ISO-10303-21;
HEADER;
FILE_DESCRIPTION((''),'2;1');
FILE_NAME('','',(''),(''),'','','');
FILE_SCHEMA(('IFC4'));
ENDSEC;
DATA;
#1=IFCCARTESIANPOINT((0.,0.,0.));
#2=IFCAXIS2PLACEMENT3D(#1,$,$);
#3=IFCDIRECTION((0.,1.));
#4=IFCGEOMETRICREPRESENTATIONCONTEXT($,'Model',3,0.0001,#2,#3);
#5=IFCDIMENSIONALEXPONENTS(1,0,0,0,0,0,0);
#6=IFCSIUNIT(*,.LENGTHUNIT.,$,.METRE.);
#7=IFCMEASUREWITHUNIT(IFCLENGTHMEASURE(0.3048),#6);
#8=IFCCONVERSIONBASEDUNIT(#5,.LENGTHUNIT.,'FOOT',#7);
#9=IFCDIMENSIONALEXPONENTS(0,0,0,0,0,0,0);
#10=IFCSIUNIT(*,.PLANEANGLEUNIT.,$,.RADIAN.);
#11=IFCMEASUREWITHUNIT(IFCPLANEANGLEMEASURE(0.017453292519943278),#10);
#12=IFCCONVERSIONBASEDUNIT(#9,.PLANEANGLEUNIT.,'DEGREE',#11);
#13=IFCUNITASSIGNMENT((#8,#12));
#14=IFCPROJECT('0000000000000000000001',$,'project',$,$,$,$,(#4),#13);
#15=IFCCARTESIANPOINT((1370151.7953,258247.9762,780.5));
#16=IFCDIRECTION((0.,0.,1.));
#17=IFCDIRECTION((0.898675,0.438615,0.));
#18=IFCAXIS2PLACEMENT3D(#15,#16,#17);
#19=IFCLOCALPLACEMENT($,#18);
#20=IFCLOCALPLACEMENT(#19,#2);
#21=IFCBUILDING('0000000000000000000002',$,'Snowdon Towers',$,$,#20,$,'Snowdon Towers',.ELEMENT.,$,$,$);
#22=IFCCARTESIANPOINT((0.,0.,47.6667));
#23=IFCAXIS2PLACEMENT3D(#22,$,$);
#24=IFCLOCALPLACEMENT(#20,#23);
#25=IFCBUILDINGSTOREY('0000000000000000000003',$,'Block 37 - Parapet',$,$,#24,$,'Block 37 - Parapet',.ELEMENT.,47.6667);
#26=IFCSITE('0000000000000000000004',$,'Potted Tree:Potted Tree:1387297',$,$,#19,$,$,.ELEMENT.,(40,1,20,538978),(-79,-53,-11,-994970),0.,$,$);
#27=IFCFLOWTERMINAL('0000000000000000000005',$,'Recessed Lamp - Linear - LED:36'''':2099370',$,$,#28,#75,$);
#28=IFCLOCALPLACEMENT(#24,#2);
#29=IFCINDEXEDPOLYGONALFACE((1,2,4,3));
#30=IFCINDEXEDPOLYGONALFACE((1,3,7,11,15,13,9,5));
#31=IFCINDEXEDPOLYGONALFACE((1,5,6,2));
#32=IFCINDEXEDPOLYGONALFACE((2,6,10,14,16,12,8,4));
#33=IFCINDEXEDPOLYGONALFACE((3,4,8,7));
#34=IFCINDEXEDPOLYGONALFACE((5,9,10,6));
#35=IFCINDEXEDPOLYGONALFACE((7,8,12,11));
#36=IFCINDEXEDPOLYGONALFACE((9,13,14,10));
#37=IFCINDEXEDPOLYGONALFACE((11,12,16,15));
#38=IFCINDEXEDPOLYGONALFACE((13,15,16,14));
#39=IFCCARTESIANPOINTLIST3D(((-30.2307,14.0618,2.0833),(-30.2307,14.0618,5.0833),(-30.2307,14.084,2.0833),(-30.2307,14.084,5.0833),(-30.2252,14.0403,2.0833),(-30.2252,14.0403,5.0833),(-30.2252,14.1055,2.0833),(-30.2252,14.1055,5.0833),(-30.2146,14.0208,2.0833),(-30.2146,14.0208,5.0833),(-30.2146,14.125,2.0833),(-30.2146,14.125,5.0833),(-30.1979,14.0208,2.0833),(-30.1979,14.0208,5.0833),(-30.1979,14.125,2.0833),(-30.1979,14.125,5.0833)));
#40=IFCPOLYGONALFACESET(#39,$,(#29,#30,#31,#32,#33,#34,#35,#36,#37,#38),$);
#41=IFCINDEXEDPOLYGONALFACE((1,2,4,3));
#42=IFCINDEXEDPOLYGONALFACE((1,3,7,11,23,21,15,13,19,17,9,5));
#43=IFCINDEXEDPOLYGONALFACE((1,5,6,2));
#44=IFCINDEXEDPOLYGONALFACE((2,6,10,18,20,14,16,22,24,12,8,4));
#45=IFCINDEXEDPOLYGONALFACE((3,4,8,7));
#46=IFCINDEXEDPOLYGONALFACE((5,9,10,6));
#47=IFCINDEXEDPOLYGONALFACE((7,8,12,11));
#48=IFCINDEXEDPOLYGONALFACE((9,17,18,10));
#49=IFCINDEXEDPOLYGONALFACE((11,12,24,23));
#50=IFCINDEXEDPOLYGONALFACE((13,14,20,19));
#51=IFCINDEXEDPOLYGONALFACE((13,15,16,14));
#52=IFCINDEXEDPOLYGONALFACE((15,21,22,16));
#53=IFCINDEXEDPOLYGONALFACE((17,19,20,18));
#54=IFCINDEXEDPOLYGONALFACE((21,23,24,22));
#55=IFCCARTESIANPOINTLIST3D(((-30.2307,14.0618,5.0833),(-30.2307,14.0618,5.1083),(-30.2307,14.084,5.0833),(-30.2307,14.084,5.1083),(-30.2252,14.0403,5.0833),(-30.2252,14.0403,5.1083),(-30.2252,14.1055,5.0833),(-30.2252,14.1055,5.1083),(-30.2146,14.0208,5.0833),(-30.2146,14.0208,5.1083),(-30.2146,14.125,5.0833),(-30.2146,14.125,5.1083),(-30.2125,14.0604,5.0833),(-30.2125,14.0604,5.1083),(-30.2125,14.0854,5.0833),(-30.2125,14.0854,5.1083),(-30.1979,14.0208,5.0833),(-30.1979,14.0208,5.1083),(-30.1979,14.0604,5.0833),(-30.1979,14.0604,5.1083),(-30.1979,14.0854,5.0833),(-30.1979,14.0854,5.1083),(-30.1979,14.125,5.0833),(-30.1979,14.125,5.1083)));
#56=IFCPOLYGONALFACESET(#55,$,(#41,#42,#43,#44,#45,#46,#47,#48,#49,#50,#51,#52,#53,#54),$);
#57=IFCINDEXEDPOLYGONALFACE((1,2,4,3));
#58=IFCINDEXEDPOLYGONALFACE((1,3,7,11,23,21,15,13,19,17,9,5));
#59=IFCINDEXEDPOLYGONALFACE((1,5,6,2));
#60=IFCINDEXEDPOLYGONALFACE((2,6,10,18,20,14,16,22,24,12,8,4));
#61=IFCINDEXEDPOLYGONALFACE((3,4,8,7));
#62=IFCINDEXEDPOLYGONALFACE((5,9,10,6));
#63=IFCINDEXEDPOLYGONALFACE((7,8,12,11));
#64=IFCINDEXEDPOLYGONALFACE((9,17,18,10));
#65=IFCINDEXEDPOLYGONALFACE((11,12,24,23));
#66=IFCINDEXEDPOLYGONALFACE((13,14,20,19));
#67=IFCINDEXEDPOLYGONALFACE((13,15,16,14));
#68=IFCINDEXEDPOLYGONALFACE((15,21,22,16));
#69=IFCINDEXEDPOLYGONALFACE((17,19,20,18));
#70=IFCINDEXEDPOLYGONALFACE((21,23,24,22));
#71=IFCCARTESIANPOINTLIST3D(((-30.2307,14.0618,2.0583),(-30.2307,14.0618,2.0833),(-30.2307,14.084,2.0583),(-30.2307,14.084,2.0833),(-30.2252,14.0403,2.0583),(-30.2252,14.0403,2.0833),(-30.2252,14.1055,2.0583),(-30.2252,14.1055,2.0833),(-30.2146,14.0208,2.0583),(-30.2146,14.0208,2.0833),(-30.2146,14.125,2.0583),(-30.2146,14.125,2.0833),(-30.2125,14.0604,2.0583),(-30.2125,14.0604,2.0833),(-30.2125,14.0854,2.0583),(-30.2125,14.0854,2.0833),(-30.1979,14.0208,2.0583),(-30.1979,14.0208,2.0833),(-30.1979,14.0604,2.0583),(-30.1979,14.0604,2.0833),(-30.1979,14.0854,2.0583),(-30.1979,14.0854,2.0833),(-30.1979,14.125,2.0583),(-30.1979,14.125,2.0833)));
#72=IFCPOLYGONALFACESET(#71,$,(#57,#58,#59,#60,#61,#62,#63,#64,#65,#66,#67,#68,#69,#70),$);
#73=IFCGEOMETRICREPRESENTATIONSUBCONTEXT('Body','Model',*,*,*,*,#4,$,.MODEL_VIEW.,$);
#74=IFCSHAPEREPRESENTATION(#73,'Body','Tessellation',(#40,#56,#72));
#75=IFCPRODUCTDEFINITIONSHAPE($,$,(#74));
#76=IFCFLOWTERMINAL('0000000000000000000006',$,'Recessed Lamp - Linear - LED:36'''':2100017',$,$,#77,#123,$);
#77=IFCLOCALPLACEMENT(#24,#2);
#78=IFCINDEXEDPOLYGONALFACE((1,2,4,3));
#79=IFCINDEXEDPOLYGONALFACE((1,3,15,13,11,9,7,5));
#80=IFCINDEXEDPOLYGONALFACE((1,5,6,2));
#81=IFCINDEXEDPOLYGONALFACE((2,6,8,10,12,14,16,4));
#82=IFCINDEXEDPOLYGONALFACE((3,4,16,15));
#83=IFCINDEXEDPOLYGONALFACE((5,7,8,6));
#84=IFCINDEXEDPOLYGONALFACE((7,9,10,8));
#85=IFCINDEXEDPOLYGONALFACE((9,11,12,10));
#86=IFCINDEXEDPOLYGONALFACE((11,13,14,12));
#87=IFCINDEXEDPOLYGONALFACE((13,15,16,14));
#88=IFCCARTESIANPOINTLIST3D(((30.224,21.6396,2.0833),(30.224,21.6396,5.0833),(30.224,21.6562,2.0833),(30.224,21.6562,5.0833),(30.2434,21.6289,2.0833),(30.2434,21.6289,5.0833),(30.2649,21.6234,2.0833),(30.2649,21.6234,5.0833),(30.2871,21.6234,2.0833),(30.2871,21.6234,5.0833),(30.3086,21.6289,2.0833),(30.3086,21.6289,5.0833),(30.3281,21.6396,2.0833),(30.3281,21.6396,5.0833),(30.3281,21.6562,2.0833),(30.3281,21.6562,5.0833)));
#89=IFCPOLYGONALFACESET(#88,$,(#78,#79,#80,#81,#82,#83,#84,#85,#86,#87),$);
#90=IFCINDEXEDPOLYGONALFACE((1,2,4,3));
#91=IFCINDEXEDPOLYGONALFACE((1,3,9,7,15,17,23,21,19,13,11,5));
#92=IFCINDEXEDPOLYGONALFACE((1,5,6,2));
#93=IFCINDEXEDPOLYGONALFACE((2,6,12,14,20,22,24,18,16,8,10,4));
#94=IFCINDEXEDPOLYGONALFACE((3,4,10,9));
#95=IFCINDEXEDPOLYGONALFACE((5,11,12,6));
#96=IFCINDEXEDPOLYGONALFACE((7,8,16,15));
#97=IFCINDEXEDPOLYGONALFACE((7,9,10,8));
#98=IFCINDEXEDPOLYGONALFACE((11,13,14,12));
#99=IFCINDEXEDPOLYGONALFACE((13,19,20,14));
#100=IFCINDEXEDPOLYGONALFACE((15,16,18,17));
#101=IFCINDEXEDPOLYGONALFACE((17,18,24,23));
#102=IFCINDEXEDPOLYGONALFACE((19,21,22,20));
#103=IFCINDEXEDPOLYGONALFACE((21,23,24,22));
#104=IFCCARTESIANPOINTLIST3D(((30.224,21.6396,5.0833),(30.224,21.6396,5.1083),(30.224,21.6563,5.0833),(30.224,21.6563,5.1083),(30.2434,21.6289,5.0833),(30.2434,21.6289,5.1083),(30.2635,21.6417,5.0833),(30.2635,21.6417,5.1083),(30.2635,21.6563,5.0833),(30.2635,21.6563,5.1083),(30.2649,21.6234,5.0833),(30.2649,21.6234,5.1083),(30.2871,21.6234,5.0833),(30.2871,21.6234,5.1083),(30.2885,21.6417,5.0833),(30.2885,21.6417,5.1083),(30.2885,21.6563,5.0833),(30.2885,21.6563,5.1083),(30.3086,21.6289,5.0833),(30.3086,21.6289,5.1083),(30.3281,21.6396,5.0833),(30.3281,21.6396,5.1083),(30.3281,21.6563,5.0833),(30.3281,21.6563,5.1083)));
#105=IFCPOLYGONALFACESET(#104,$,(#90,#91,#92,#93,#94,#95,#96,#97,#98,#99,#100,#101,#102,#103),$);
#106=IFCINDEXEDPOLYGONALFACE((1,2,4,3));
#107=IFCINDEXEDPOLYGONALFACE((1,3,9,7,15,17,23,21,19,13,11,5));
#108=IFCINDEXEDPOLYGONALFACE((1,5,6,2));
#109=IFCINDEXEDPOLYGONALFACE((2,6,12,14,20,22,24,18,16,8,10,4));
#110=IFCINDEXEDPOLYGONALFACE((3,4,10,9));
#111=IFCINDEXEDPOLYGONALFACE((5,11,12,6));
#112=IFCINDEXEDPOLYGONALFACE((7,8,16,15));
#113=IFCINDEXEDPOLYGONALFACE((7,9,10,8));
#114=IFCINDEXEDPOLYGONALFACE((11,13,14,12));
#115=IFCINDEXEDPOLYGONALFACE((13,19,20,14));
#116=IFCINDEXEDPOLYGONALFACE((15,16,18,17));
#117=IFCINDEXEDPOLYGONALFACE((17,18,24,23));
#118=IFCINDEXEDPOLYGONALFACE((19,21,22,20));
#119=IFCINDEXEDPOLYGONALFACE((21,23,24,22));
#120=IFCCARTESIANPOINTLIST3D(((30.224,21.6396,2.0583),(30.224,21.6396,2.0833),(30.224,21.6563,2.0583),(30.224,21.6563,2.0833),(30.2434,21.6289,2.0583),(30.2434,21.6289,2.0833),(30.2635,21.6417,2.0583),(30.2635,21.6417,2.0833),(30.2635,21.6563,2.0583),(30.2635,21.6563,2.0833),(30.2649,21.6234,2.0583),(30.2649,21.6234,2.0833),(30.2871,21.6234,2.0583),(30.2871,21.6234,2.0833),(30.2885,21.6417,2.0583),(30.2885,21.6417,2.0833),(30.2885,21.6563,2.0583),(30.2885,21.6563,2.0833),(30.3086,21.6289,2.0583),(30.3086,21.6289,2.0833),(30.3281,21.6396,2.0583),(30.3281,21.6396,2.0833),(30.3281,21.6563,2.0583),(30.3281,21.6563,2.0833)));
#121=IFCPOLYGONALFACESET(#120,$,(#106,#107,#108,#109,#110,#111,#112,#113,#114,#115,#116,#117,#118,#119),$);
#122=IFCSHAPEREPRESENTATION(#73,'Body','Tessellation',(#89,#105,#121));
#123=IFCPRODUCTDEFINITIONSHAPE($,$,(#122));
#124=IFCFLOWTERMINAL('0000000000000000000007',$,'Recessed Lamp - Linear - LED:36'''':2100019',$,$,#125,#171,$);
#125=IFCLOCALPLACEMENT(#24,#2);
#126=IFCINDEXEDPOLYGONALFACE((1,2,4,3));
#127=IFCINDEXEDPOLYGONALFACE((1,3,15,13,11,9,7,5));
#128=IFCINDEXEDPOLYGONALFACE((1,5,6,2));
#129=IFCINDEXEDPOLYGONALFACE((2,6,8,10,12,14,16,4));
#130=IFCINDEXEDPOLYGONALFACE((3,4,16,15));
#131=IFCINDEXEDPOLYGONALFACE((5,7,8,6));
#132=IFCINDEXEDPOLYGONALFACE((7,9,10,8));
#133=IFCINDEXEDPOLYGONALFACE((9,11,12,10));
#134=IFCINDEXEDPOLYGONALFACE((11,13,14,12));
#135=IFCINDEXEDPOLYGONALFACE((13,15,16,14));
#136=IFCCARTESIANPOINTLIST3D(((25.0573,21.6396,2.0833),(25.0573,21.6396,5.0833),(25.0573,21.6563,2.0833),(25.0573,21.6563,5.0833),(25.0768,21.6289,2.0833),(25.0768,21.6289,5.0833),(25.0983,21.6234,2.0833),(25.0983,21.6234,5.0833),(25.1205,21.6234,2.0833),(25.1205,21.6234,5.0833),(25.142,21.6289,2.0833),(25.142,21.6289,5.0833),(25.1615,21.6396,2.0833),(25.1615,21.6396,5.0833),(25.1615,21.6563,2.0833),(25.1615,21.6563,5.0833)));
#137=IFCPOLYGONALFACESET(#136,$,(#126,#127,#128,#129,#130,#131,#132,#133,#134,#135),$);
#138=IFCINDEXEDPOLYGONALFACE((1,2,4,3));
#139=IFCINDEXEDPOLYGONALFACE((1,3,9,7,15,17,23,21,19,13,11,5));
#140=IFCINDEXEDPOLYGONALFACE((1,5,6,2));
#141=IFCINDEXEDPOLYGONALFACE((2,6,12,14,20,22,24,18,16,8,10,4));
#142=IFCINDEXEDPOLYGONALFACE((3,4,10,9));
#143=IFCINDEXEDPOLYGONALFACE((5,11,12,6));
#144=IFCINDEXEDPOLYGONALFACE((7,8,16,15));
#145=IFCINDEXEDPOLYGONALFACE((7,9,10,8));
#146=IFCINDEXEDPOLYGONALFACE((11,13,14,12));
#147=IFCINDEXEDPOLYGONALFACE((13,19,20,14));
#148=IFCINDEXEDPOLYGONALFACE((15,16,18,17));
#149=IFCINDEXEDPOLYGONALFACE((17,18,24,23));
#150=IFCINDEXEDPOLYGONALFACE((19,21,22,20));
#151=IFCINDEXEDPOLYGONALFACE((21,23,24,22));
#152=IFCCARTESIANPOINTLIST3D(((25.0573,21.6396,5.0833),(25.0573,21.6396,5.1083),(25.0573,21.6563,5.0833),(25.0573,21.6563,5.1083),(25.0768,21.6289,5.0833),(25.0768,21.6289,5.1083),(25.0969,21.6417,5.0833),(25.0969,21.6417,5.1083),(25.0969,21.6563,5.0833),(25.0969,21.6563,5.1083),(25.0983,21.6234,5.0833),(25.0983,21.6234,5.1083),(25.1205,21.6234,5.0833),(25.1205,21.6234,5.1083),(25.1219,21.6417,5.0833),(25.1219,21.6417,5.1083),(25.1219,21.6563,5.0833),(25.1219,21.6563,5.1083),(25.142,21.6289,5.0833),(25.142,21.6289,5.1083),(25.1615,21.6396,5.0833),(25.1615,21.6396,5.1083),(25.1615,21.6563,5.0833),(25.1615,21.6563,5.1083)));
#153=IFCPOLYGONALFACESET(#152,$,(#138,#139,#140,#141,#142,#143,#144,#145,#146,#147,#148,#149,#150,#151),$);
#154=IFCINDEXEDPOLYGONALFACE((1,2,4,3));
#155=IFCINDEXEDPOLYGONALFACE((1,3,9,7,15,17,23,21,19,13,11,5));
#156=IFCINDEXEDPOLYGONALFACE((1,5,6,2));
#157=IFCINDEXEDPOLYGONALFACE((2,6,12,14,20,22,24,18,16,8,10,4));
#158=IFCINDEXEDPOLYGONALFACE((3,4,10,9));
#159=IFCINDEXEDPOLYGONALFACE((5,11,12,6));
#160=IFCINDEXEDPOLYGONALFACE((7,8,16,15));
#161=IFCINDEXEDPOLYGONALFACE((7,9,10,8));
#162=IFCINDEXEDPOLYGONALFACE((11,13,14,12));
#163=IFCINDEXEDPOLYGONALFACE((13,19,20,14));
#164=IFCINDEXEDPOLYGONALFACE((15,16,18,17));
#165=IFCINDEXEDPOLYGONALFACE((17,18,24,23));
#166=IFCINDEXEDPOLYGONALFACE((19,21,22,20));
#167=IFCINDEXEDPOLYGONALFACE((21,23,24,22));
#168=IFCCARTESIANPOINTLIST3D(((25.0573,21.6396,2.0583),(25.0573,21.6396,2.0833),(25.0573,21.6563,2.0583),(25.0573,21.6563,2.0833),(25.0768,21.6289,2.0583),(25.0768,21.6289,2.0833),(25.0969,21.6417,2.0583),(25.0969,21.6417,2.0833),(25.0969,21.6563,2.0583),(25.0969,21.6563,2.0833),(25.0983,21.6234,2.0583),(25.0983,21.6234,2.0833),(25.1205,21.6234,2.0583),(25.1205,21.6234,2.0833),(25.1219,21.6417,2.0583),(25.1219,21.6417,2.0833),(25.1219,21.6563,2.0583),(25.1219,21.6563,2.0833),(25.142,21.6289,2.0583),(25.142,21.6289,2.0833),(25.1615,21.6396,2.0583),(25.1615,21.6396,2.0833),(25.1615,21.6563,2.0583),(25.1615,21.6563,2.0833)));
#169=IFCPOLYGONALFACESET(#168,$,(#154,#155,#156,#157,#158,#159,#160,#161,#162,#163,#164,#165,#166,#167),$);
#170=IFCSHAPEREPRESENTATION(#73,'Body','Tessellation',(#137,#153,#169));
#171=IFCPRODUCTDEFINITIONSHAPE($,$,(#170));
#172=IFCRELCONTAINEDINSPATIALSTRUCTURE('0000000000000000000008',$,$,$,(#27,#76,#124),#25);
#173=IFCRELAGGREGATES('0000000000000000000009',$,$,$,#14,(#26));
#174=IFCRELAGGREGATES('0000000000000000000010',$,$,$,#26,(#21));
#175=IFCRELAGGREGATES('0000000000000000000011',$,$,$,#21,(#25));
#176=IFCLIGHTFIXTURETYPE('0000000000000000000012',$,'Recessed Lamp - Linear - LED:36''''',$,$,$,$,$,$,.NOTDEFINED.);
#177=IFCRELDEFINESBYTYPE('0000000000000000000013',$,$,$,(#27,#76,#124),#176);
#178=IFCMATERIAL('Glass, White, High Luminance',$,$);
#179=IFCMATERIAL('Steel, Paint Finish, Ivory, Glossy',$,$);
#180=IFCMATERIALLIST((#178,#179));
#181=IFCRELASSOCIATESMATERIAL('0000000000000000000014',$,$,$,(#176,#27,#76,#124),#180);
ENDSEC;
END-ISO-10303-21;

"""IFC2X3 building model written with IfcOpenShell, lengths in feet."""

from ifc_helpers import new_model, entity, si_unit, converted_unit, direction, frame, frame_2d, origin, place, context, subcontext, project, spatial, polyline, circle_curve, parameter, trimmed, segment, composite_curve, outline, extrude, source, transform, mapped, material, material_list, type_object, type_shapes, element, save


model = new_model("IFC2X3")

# Units and contexts
model_context = context("Model", 3, precision=0.0001, world=origin(), true_north=direction((0.0, 1.0)))
body_context = subcontext(model_context, "Body", "Model", "MODEL_VIEW")
ifc_project = project(units=[converted_unit("LENGTHUNIT", "FOOT", entity("IfcLengthMeasure", 0.3048), si_unit("LENGTHUNIT", "METRE"), dimensions=[1, 0, 0, 0, 0, 0, 0]), converted_unit("PLANEANGLEUNIT", "DEGREE", entity("IfcPlaneAngleMeasure", 0.017453292519943278), si_unit("PLANEANGLEUNIT", "RADIAN"), dimensions=[0, 0, 0, 0, 0, 0, 0])], contexts=[model_context])

# Site, building, storey
site_placement = place(None, frame((1370151.7953, 258247.9762, 780.5), z_axis=(0.0, 0.0, 1.0), x_axis=(0.898675, 0.438615, 0.0)))
site = spatial("IfcSite", under=ifc_project, at=site_placement, Name="Potted Tree:Potted Tree:1387297", CompositionType="ELEMENT", RefLatitude=(40, 1, 20, 538978), RefLongitude=(-79, -53, -11, -994970), RefElevation=0.0)
building_placement = place(site_placement, origin())
building = spatial("IfcBuilding", under=site, at=building_placement, Name="Snowdon Towers", LongName="Snowdon Towers", CompositionType="ELEMENT")
storey_placement = place(building_placement, frame((0.0, 0.0, 47.6667)))
storey = spatial("IfcBuildingStorey", under=building, at=storey_placement, Name="Block 37 - Parapet", LongName="Block 37 - Parapet", CompositionType="ELEMENT", Elevation=47.6667)

# Flow terminals
ifc_material_1 = material(Name="Glass, White, High Luminance")
ifc_material_2 = material(Name="Steel, Paint Finish, Ivory, Glossy")
ifc_material_list = material_list([ifc_material_1, ifc_material_2])
light_fixture_type = type_object("IfcLightFixtureType", Name="Recessed Lamp - Linear - LED:36''", PredefinedType="NOTDEFINED", material=ifc_material_list)
shared_shape = source(origin(), body_context, "Body", "SweptSolid", [
    extrude(outline(composite_curve([segment(trimmed(circle_curve(frame_2d((0.0, -0.0639), x_axis=(1.0, 0.0)), 0.089), [parameter(54.196986)], [parameter(125.803014)], True, "PARAMETER"), True, "CONTINUOUS"), segment(polyline([(-0.0521, 0.0083), (-0.0521, -0.0083)]), True, "CONTINUOUS"), segment(polyline([(-0.0521, -0.0083), (0.0521, -0.0083)]), True, "CONTINUOUS"), segment(polyline([(0.0521, -0.0083), (0.0521, 0.0083)]), True, "CONTINUOUS")], self_intersect=False)), frame((-1.5, 0.0, 0.0083), z_axis=(1.0, 0.0, 0.0), x_axis=(0.0, 1.0, 0.0)), (0.0, 0.0, 1.0), 3.0),
    extrude(outline(composite_curve([segment(trimmed(circle_curve(frame_2d((0.0, -0.0633), x_axis=(1.0, 0.0)), 0.089), [parameter(54.196986)], [parameter(125.803014)], True, "PARAMETER"), True, "CONTINUOUS"), segment(polyline([(-0.0521, 0.0089), (-0.0521, -0.0078)]), True, "CONTINUOUS"), segment(polyline([(-0.0521, -0.0078), (-0.0125, -0.0078)]), True, "CONTINUOUS"), segment(polyline([(-0.0125, -0.0078), (-0.0125, 0.0068)]), True, "CONTINUOUS"), segment(polyline([(-0.0125, 0.0068), (0.0125, 0.0068)]), True, "CONTINUOUS"), segment(polyline([(0.0125, 0.0068), (0.0125, -0.0078)]), True, "CONTINUOUS"), segment(polyline([(0.0125, -0.0078), (0.0521, -0.0078)]), True, "CONTINUOUS"), segment(polyline([(0.0521, -0.0078), (0.0521, 0.0089)]), True, "CONTINUOUS")], self_intersect=False)), frame((1.5, 0.0, 0.0078), z_axis=(1.0, 0.0, 0.0), x_axis=(0.0, 1.0, 0.0)), (0.0, 0.0, 1.0), 0.025),
    extrude(outline(composite_curve([segment(trimmed(circle_curve(frame_2d((0.0, -0.0633), x_axis=(1.0, 0.0)), 0.089), [parameter(54.196986)], [parameter(125.803014)], True, "PARAMETER"), True, "CONTINUOUS"), segment(polyline([(-0.0521, 0.0089), (-0.0521, -0.0078)]), True, "CONTINUOUS"), segment(polyline([(-0.0521, -0.0078), (-0.0125, -0.0078)]), True, "CONTINUOUS"), segment(polyline([(-0.0125, -0.0078), (-0.0125, 0.0068)]), True, "CONTINUOUS"), segment(polyline([(-0.0125, 0.0068), (0.0125, 0.0068)]), True, "CONTINUOUS"), segment(polyline([(0.0125, 0.0068), (0.0125, -0.0078)]), True, "CONTINUOUS"), segment(polyline([(0.0125, -0.0078), (0.0521, -0.0078)]), True, "CONTINUOUS"), segment(polyline([(0.0521, -0.0078), (0.0521, 0.0089)]), True, "CONTINUOUS")], self_intersect=False)), frame((-1.525, 0.0, 0.0078), z_axis=(1.0, 0.0, 0.0), x_axis=(0.0, 1.0, 0.0)), (0.0, 0.0, 1.0), 0.025),
])
type_shapes(light_fixture_type, [shared_shape])
for number, where, z_axis, x_axis, name in (
    (1, (-30.1979, 14.0729, 3.5833), (-1.0, 0.0, 0.0), (0.0, 0.0, 1.0), "Recessed Lamp - Linear - LED:36'':2099370"),
    (2, (30.276, 21.6562, 3.5833), (0.0, -1.0, 0.0), (0.0, 0.0, 1.0), "Recessed Lamp - Linear - LED:36'':2100017"),
    (3, (25.1094, 21.6562, 3.5833), (0.0, -1.0, 0.0), (0.0, 0.0, 1.0), "Recessed Lamp - Linear - LED:36'':2100019"),
):
    element("IfcFlowTerminal", number, at=place(storey_placement, frame(where, z_axis=z_axis, x_axis=x_axis)), inside=storey, type_object=light_fixture_type, material=ifc_material_list, Name=name, context=body_context, shape_type="MappedRepresentation", body=[
        mapped(shared_shape, transform((0.0, 0.0, 0.0), scale=1.0)),
    ])

save(model, "model.ifc")
